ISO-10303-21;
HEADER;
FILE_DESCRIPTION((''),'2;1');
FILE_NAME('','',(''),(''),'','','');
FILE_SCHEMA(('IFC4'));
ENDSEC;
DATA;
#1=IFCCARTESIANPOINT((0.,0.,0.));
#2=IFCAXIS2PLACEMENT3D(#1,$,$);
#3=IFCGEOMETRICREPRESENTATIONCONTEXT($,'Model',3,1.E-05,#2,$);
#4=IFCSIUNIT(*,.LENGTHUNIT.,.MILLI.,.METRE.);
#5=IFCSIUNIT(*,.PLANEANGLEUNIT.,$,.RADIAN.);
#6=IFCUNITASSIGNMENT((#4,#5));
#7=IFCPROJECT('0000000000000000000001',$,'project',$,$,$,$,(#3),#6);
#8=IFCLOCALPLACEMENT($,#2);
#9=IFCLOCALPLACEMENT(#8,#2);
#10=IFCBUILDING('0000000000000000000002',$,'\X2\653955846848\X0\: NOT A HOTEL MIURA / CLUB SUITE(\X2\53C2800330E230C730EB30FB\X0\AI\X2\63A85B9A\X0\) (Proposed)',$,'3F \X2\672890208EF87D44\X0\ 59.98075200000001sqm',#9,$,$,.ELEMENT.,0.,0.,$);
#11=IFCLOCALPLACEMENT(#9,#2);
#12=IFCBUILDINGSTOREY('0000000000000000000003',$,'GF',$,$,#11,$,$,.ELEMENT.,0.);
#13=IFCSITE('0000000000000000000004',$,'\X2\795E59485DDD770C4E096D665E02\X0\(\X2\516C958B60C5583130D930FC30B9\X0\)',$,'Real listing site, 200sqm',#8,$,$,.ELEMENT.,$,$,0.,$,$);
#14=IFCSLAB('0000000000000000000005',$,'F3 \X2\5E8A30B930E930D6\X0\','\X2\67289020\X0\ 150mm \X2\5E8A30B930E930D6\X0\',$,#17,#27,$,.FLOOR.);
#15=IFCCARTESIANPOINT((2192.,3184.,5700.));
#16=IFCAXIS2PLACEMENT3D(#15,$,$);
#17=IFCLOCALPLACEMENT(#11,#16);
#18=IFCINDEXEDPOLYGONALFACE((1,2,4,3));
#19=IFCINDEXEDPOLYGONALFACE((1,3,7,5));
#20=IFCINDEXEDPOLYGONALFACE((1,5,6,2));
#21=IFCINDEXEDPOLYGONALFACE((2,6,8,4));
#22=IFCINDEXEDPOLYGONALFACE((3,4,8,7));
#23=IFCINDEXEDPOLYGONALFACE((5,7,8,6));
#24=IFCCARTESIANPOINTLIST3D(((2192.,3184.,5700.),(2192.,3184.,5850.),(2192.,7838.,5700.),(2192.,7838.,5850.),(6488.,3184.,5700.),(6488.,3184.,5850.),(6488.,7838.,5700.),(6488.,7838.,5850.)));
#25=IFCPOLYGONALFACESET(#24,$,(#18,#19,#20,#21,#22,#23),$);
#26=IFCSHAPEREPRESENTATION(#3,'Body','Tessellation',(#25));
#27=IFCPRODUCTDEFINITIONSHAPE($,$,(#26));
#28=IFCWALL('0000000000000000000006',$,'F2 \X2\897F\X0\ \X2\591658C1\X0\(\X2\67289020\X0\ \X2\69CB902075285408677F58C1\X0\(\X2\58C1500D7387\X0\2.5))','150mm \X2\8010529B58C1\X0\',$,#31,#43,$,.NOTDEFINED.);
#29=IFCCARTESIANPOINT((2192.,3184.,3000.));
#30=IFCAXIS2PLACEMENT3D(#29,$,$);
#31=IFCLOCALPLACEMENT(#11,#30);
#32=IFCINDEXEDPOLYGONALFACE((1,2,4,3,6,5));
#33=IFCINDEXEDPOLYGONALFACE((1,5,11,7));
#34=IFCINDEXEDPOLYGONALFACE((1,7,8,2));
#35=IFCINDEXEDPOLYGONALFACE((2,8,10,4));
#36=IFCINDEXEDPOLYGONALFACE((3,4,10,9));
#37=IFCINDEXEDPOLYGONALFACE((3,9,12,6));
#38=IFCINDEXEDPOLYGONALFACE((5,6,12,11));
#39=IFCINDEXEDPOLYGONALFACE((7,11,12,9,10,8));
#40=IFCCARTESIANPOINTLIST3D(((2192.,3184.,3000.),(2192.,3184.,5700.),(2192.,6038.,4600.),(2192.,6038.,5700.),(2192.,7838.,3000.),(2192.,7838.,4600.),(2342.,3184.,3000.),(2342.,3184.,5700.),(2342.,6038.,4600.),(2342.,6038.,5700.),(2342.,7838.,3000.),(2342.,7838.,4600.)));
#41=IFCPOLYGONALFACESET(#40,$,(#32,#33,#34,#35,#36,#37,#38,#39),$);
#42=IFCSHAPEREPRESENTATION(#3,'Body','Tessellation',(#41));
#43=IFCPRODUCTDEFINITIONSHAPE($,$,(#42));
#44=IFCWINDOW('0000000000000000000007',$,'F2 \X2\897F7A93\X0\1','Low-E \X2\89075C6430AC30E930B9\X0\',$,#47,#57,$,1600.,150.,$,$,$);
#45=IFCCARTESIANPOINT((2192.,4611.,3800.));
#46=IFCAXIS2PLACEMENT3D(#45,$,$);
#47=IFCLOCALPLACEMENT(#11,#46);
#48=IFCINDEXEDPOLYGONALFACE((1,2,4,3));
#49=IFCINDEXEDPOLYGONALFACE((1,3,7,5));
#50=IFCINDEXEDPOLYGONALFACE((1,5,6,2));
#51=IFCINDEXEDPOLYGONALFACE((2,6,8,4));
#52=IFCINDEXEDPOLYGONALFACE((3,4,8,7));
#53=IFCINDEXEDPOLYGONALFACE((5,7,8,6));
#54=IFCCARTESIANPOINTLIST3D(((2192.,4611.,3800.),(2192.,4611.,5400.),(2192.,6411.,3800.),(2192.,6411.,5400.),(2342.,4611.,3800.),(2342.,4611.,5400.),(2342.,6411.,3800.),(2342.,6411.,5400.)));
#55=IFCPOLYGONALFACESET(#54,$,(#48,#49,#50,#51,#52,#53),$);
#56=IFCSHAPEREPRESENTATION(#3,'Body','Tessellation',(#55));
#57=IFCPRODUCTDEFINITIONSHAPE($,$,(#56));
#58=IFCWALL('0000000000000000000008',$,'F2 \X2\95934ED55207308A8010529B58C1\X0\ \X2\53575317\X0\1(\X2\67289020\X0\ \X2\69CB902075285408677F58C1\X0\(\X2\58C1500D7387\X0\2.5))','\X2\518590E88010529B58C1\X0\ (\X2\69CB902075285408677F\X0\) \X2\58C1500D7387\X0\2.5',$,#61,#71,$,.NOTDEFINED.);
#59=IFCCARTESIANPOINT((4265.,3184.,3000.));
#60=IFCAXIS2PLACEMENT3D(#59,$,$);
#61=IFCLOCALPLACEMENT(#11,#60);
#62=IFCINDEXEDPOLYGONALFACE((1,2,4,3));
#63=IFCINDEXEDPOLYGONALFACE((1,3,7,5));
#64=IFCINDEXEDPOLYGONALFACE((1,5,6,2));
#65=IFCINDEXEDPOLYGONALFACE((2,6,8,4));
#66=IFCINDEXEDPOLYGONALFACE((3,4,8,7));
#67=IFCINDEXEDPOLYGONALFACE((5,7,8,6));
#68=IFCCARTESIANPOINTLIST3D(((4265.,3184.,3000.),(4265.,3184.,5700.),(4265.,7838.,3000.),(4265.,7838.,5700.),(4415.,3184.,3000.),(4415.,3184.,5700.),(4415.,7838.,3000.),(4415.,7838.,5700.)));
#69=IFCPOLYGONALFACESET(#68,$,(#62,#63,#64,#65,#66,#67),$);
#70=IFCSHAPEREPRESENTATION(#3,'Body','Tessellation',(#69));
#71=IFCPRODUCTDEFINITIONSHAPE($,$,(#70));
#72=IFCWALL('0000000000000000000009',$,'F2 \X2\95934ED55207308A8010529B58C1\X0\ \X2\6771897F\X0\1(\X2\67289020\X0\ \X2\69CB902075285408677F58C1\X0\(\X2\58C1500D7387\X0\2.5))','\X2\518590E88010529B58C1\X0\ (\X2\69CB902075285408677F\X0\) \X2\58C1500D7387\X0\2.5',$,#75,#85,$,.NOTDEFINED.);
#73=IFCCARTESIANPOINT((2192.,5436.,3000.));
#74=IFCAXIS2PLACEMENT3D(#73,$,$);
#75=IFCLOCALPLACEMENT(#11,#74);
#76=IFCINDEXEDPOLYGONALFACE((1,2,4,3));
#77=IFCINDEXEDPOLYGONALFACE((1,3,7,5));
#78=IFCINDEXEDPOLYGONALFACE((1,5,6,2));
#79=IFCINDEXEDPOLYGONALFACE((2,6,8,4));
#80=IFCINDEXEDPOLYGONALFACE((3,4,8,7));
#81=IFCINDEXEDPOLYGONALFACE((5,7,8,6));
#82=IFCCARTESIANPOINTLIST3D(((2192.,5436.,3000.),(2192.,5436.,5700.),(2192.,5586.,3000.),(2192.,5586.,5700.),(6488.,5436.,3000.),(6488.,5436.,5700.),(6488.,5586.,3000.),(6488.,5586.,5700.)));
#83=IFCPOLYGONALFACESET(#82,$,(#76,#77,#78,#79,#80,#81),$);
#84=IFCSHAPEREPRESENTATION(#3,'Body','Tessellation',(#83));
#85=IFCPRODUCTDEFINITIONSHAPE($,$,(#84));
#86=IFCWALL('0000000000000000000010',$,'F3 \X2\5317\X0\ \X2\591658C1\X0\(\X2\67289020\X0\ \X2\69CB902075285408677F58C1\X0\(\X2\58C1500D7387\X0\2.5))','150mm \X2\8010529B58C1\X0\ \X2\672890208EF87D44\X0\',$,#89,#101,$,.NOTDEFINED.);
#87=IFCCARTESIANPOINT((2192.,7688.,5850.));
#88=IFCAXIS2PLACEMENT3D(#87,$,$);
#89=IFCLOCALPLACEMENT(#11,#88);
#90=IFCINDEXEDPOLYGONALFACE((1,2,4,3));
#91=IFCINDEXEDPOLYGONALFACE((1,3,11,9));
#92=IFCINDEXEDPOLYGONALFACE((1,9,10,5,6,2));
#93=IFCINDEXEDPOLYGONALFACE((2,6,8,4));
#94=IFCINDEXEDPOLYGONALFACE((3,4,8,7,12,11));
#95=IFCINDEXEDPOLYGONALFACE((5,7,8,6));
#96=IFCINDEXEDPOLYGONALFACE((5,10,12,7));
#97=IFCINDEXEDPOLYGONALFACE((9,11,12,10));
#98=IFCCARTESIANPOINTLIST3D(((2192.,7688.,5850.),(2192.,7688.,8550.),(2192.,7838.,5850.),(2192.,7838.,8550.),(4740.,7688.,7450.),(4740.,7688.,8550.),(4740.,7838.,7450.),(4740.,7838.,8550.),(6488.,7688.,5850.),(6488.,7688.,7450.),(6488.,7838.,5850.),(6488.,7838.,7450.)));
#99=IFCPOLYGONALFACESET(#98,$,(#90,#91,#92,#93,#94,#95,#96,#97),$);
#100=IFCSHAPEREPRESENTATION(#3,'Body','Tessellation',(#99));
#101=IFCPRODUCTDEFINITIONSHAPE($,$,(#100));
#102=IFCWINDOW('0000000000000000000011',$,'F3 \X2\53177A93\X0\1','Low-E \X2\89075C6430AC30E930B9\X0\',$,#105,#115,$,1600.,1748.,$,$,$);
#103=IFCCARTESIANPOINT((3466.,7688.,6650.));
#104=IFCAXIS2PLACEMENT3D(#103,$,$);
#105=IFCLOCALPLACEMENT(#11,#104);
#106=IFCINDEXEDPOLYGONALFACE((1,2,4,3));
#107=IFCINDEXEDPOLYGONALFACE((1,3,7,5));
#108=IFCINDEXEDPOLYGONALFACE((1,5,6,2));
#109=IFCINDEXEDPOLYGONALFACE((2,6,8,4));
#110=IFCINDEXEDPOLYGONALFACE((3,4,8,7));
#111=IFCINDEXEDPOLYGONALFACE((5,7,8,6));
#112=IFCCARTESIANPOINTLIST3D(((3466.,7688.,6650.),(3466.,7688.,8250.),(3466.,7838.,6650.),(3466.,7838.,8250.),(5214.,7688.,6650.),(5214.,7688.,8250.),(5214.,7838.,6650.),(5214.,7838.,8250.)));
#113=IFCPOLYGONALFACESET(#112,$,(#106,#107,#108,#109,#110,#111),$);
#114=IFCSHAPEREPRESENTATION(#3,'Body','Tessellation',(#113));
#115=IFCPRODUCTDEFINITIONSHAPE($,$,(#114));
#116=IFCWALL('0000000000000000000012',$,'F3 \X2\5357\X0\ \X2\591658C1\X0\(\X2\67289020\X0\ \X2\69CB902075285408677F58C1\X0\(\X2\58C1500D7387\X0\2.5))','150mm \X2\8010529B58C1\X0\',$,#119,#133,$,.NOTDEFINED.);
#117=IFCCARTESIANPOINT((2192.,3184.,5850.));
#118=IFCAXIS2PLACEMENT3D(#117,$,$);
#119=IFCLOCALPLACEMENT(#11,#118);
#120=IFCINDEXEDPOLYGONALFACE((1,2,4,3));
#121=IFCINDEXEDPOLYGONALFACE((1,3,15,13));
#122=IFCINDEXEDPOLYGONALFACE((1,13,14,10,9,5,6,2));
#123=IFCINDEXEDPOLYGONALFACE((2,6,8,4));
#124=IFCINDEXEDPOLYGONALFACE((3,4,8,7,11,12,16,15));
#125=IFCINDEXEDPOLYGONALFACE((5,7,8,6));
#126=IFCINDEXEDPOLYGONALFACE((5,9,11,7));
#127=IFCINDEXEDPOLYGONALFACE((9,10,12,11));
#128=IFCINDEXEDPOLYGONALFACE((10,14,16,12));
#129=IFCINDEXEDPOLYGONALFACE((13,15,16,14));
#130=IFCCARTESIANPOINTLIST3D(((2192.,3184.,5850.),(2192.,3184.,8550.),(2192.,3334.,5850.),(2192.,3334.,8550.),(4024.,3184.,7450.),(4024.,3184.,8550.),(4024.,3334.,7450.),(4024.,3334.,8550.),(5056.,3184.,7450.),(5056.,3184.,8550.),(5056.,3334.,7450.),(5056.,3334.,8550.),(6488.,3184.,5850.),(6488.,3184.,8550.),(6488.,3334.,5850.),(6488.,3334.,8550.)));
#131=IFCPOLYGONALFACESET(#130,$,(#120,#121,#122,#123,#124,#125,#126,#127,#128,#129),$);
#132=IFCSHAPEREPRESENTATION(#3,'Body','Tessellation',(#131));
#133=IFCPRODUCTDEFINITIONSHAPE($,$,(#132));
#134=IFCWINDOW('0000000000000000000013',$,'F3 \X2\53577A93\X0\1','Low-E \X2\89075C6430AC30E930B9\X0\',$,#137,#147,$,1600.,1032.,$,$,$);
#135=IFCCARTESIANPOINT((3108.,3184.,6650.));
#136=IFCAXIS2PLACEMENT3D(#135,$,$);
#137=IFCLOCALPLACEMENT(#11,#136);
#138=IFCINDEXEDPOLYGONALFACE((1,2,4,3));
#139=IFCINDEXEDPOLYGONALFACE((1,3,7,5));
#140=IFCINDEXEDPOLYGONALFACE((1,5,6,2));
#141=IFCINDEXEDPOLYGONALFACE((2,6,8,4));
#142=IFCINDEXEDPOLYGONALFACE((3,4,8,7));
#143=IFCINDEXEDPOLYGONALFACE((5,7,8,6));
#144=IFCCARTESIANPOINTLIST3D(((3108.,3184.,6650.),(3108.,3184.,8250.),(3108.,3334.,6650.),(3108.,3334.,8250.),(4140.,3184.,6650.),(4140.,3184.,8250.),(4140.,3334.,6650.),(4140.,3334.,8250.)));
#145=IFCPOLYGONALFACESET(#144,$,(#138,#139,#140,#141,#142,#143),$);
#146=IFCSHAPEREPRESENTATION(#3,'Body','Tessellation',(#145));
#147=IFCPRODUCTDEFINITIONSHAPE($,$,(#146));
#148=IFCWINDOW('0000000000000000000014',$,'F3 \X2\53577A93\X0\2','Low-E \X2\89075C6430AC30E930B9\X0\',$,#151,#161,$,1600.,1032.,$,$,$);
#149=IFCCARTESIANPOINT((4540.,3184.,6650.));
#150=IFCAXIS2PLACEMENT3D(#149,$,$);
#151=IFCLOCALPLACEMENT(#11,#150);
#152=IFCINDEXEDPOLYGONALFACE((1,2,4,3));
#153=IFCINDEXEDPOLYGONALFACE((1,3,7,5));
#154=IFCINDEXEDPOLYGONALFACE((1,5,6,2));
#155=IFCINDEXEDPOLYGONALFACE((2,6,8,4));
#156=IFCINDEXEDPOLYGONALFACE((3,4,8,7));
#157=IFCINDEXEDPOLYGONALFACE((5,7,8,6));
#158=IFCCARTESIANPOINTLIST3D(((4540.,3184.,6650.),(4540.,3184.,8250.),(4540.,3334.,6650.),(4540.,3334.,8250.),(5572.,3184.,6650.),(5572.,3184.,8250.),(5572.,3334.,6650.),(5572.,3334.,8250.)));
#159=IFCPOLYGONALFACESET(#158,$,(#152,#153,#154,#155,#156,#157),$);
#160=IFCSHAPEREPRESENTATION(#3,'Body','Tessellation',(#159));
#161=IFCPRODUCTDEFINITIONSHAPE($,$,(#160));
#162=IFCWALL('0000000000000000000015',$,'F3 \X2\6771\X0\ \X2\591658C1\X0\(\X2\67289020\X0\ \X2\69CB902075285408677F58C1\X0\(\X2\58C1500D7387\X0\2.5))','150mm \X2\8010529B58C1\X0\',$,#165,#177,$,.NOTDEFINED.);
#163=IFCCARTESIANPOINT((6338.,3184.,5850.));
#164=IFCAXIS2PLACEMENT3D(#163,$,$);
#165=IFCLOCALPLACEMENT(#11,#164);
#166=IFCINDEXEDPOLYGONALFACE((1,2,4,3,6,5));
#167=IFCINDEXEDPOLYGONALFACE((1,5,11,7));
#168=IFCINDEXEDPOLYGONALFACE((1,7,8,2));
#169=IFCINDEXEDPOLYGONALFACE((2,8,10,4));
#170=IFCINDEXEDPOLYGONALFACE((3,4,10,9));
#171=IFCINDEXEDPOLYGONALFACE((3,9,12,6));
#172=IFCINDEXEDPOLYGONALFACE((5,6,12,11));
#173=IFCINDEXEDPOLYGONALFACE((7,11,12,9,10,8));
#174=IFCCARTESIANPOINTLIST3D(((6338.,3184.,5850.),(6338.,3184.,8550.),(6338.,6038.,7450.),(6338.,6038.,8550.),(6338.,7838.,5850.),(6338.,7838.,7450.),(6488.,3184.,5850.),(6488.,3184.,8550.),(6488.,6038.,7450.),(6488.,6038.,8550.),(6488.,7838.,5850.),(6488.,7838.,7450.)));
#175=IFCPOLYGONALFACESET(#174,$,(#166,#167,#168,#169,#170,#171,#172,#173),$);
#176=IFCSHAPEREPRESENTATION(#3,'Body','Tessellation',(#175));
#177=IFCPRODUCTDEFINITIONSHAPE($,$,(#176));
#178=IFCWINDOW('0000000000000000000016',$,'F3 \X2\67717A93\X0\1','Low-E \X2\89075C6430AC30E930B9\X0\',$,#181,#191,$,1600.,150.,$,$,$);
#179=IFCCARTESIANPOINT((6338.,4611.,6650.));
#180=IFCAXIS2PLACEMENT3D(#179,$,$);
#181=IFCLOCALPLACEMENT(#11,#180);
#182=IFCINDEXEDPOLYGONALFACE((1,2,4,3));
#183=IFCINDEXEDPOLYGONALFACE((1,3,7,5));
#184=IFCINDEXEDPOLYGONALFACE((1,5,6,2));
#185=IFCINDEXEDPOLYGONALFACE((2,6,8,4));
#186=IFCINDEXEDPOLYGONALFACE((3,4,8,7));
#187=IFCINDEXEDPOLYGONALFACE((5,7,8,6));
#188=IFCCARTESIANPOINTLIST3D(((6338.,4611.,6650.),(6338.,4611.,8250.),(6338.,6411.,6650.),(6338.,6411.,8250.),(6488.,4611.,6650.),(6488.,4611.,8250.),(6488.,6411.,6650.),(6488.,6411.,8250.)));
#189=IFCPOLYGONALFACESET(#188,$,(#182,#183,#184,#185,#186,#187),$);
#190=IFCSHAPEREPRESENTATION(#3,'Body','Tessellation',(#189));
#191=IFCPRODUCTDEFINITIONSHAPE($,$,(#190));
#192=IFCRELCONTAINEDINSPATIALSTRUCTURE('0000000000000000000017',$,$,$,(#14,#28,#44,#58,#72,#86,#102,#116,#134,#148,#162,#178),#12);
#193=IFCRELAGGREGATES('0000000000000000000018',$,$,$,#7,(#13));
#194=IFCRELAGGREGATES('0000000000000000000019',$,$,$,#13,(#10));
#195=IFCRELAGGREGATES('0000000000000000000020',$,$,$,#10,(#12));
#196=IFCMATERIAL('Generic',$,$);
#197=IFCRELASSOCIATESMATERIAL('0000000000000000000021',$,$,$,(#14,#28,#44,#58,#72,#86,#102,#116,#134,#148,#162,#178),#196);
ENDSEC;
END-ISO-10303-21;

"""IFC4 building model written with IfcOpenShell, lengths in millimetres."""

from ifc_helpers import new_model, si_unit, frame, frame_2d, origin, place, context, project, spatial, rectangle, extrude, material, element, fill, save


model = new_model("IFC4")

# Units and contexts
model_context = context("Model", 3, precision=1e-05, world=origin())
ifc_project = project(units=[si_unit("LENGTHUNIT", "METRE", prefix="MILLI"), si_unit("PLANEANGLEUNIT", "RADIAN")], contexts=[model_context])

# Site, building, storey
site_placement = place(None, origin())
site = spatial("IfcSite", under=ifc_project, at=site_placement, Name="神奈川県三浦市(公開情報ベース)", ObjectType="Real listing site, 200sqm", CompositionType="ELEMENT", RefElevation=0.0)
building_placement = place(site_placement, origin())
building = spatial("IfcBuilding", under=site, at=building_placement, Name="改善案: NOT A HOTEL MIURA / CLUB SUITE(参考モデル・AI推定) (Proposed)", ObjectType="3F 木造軸組 59.98075200000001sqm", CompositionType="ELEMENT", ElevationOfRefHeight=0.0, ElevationOfTerrain=0.0)
storey_placement = place(building_placement, origin())
storey = spatial("IfcBuildingStorey", under=building, at=storey_placement, Name="GF", CompositionType="ELEMENT", Elevation=0.0)

# Slab
ifc_material_1 = material(Name="Generic")
slab_placement = place(storey_placement, frame((2192.0, 3184.0, 5700.0)))
element("IfcSlab", 1, at=slab_placement, inside=storey, material=ifc_material_1, Name="F3 床スラブ", Description="木造 150mm 床スラブ", PredefinedType="FLOOR", context=model_context, shape_type="SweptSolid", body=[
    extrude(rectangle(XDim=4296.0, YDim=4654.0, at=frame_2d((2148.0, 2327.0))), frame((2192.0, 3184.0, 5700.0)), (0.0, 0.0, 1.0), 150.0),
])

# Wall, opening, window
wall_1_placement = place(storey_placement, frame((2192.0, 3184.0, 3000.0)))
wall_1 = element("IfcWall", 2, at=wall_1_placement, inside=storey, material=ifc_material_1, Name="F2 西 外壁(木造 構造用合板壁(壁倍率2.5))", Description="150mm 耐力壁", PredefinedType="NOTDEFINED", context=model_context, shape_type="SweptSolid", body=[
    extrude(rectangle(XDim=150.0, YDim=4654.0, at=frame_2d((75.0, 2327.0))), frame((2192.0, 3184.0, 3000.0)), (0.0, 0.0, 1.0), 2700.0),
])
opening_1_placement = place(storey_placement, frame((2192.0, 4611.0, 3800.0)))
opening_1 = element("IfcOpeningElement", 3, at=opening_1_placement, cuts=wall_1, PredefinedType="NOTDEFINED", context=model_context, shape_type="SweptSolid", body=[
    extrude(rectangle(XDim=150.0, YDim=1800.0, at=frame_2d((75.0, 900.0))), frame((2192.0, 4611.0, 3800.0)), (0.0, 0.0, 1.0), 1600.0),
])
window_1_placement = place(storey_placement, frame((2192.0, 4611.0, 3800.0)))
window_1 = element("IfcWindow", 4, at=window_1_placement, inside=storey, material=ifc_material_1, Name="F2 西窓1", Description="Low-E 複層ガラス", OverallHeight=1600.0, OverallWidth=150.0, context=model_context, shape_type="SweptSolid", body=[
    extrude(rectangle(XDim=150.0, YDim=1800.0, at=frame_2d((75.0, 900.0))), frame((2192.0, 4611.0, 3800.0)), (0.0, 0.0, 1.0), 1600.0),
])
fill(opening_1, window_1)

# Walls
wall_2_placement = place(storey_placement, frame((4265.0, 3184.0, 3000.0)))
element("IfcWall", 5, at=wall_2_placement, inside=storey, material=ifc_material_1, Name="F2 間仕切り耐力壁 南北1(木造 構造用合板壁(壁倍率2.5))", Description="内部耐力壁 (構造用合板) 壁倍率2.5", PredefinedType="NOTDEFINED", context=model_context, shape_type="SweptSolid", body=[
    extrude(rectangle(XDim=150.0, YDim=4654.0, at=frame_2d((75.0, 2327.0))), frame((4265.0, 3184.0, 3000.0)), (0.0, 0.0, 1.0), 2700.0),
])
wall_3_placement = place(storey_placement, frame((2192.0, 5436.0, 3000.0)))
element("IfcWall", 6, at=wall_3_placement, inside=storey, material=ifc_material_1, Name="F2 間仕切り耐力壁 東西1(木造 構造用合板壁(壁倍率2.5))", Description="内部耐力壁 (構造用合板) 壁倍率2.5", PredefinedType="NOTDEFINED", context=model_context, shape_type="SweptSolid", body=[
    extrude(rectangle(XDim=4296.0, YDim=150.0, at=frame_2d((2148.0, 75.0))), frame((2192.0, 5436.0, 3000.0)), (0.0, 0.0, 1.0), 2700.0),
])

# Wall, opening, window
wall_4_placement = place(storey_placement, frame((2192.0, 7688.0, 5850.0)))
wall_4 = element("IfcWall", 7, at=wall_4_placement, inside=storey, material=ifc_material_1, Name="F3 北 外壁(木造 構造用合板壁(壁倍率2.5))", Description="150mm 耐力壁 木造軸組", PredefinedType="NOTDEFINED", context=model_context, shape_type="SweptSolid", body=[
    extrude(rectangle(XDim=4296.0, YDim=150.0, at=frame_2d((2148.0, 75.0))), frame((2192.0, 7688.0, 5850.0)), (0.0, 0.0, 1.0), 2700.0),
])
opening_2_placement = place(storey_placement, frame((3466.0, 7688.0, 6650.0)))
opening_2 = element("IfcOpeningElement", 8, at=opening_2_placement, cuts=wall_4, PredefinedType="NOTDEFINED", context=model_context, shape_type="SweptSolid", body=[
    extrude(rectangle(XDim=1748.0, YDim=150.0, at=frame_2d((874.0, 75.0))), frame((3466.0, 7688.0, 6650.0)), (0.0, 0.0, 1.0), 1600.0),
])
window_2_placement = place(storey_placement, frame((3466.0, 7688.0, 6650.0)))
window_2 = element("IfcWindow", 9, at=window_2_placement, inside=storey, material=ifc_material_1, Name="F3 北窓1", Description="Low-E 複層ガラス", OverallHeight=1600.0, OverallWidth=1748.0, context=model_context, shape_type="SweptSolid", body=[
    extrude(rectangle(XDim=1748.0, YDim=150.0, at=frame_2d((874.0, 75.0))), frame((3466.0, 7688.0, 6650.0)), (0.0, 0.0, 1.0), 1600.0),
])
fill(opening_2, window_2)

# Wall, openings, windows
wall_5_placement = place(storey_placement, frame((2192.0, 3184.0, 5850.0)))
wall_5 = element("IfcWall", 10, at=wall_5_placement, inside=storey, material=ifc_material_1, Name="F3 南 外壁(木造 構造用合板壁(壁倍率2.5))", Description="150mm 耐力壁", PredefinedType="NOTDEFINED", context=model_context, shape_type="SweptSolid", body=[
    extrude(rectangle(XDim=4296.0, YDim=150.0, at=frame_2d((2148.0, 75.0))), frame((2192.0, 3184.0, 5850.0)), (0.0, 0.0, 1.0), 2700.0),
])
opening_3_placement = place(storey_placement, frame((3108.0, 3184.0, 6650.0)))
opening_3 = element("IfcOpeningElement", 11, at=opening_3_placement, cuts=wall_5, PredefinedType="NOTDEFINED", context=model_context, shape_type="SweptSolid", body=[
    extrude(rectangle(XDim=1032.0, YDim=150.0, at=frame_2d((516.0, 75.0))), frame((3108.0, 3184.0, 6650.0)), (0.0, 0.0, 1.0), 1600.0),
])
opening_4_placement = place(storey_placement, frame((4540.0, 3184.0, 6650.0)))
opening_4 = element("IfcOpeningElement", 12, at=opening_4_placement, cuts=wall_5, PredefinedType="NOTDEFINED", context=model_context, shape_type="SweptSolid", body=[
    extrude(rectangle(XDim=1032.0, YDim=150.0, at=frame_2d((516.0, 75.0))), frame((4540.0, 3184.0, 6650.0)), (0.0, 0.0, 1.0), 1600.0),
])
window_3_placement = place(storey_placement, frame((3108.0, 3184.0, 6650.0)))
window_3 = element("IfcWindow", 13, at=window_3_placement, inside=storey, material=ifc_material_1, Name="F3 南窓1", Description="Low-E 複層ガラス", OverallHeight=1600.0, OverallWidth=1032.0, context=model_context, shape_type="SweptSolid", body=[
    extrude(rectangle(XDim=1032.0, YDim=150.0, at=frame_2d((516.0, 75.0))), frame((3108.0, 3184.0, 6650.0)), (0.0, 0.0, 1.0), 1600.0),
])
fill(opening_3, window_3)
window_4_placement = place(storey_placement, frame((4540.0, 3184.0, 6650.0)))
window_4 = element("IfcWindow", 14, at=window_4_placement, inside=storey, material=ifc_material_1, Name="F3 南窓2", Description="Low-E 複層ガラス", OverallHeight=1600.0, OverallWidth=1032.0, context=model_context, shape_type="SweptSolid", body=[
    extrude(rectangle(XDim=1032.0, YDim=150.0, at=frame_2d((516.0, 75.0))), frame((4540.0, 3184.0, 6650.0)), (0.0, 0.0, 1.0), 1600.0),
])
fill(opening_4, window_4)

# Wall, opening, window
wall_6_placement = place(storey_placement, frame((6338.0, 3184.0, 5850.0)))
wall_6 = element("IfcWall", 15, at=wall_6_placement, inside=storey, material=ifc_material_1, Name="F3 東 外壁(木造 構造用合板壁(壁倍率2.5))", Description="150mm 耐力壁", PredefinedType="NOTDEFINED", context=model_context, shape_type="SweptSolid", body=[
    extrude(rectangle(XDim=150.0, YDim=4654.0, at=frame_2d((75.0, 2327.0))), frame((6338.0, 3184.0, 5850.0)), (0.0, 0.0, 1.0), 2700.0),
])
opening_5_placement = place(storey_placement, frame((6338.0, 4611.0, 6650.0)))
opening_5 = element("IfcOpeningElement", 16, at=opening_5_placement, cuts=wall_6, PredefinedType="NOTDEFINED", context=model_context, shape_type="SweptSolid", body=[
    extrude(rectangle(XDim=150.0, YDim=1800.0, at=frame_2d((75.0, 900.0))), frame((6338.0, 4611.0, 6650.0)), (0.0, 0.0, 1.0), 1600.0),
])
window_5_placement = place(storey_placement, frame((6338.0, 4611.0, 6650.0)))
window_5 = element("IfcWindow", 17, at=window_5_placement, inside=storey, material=ifc_material_1, Name="F3 東窓1", Description="Low-E 複層ガラス", OverallHeight=1600.0, OverallWidth=150.0, context=model_context, shape_type="SweptSolid", body=[
    extrude(rectangle(XDim=150.0, YDim=1800.0, at=frame_2d((75.0, 900.0))), frame((6338.0, 4611.0, 6650.0)), (0.0, 0.0, 1.0), 1600.0),
])
fill(opening_5, window_5)

save(model, "model.ifc")
